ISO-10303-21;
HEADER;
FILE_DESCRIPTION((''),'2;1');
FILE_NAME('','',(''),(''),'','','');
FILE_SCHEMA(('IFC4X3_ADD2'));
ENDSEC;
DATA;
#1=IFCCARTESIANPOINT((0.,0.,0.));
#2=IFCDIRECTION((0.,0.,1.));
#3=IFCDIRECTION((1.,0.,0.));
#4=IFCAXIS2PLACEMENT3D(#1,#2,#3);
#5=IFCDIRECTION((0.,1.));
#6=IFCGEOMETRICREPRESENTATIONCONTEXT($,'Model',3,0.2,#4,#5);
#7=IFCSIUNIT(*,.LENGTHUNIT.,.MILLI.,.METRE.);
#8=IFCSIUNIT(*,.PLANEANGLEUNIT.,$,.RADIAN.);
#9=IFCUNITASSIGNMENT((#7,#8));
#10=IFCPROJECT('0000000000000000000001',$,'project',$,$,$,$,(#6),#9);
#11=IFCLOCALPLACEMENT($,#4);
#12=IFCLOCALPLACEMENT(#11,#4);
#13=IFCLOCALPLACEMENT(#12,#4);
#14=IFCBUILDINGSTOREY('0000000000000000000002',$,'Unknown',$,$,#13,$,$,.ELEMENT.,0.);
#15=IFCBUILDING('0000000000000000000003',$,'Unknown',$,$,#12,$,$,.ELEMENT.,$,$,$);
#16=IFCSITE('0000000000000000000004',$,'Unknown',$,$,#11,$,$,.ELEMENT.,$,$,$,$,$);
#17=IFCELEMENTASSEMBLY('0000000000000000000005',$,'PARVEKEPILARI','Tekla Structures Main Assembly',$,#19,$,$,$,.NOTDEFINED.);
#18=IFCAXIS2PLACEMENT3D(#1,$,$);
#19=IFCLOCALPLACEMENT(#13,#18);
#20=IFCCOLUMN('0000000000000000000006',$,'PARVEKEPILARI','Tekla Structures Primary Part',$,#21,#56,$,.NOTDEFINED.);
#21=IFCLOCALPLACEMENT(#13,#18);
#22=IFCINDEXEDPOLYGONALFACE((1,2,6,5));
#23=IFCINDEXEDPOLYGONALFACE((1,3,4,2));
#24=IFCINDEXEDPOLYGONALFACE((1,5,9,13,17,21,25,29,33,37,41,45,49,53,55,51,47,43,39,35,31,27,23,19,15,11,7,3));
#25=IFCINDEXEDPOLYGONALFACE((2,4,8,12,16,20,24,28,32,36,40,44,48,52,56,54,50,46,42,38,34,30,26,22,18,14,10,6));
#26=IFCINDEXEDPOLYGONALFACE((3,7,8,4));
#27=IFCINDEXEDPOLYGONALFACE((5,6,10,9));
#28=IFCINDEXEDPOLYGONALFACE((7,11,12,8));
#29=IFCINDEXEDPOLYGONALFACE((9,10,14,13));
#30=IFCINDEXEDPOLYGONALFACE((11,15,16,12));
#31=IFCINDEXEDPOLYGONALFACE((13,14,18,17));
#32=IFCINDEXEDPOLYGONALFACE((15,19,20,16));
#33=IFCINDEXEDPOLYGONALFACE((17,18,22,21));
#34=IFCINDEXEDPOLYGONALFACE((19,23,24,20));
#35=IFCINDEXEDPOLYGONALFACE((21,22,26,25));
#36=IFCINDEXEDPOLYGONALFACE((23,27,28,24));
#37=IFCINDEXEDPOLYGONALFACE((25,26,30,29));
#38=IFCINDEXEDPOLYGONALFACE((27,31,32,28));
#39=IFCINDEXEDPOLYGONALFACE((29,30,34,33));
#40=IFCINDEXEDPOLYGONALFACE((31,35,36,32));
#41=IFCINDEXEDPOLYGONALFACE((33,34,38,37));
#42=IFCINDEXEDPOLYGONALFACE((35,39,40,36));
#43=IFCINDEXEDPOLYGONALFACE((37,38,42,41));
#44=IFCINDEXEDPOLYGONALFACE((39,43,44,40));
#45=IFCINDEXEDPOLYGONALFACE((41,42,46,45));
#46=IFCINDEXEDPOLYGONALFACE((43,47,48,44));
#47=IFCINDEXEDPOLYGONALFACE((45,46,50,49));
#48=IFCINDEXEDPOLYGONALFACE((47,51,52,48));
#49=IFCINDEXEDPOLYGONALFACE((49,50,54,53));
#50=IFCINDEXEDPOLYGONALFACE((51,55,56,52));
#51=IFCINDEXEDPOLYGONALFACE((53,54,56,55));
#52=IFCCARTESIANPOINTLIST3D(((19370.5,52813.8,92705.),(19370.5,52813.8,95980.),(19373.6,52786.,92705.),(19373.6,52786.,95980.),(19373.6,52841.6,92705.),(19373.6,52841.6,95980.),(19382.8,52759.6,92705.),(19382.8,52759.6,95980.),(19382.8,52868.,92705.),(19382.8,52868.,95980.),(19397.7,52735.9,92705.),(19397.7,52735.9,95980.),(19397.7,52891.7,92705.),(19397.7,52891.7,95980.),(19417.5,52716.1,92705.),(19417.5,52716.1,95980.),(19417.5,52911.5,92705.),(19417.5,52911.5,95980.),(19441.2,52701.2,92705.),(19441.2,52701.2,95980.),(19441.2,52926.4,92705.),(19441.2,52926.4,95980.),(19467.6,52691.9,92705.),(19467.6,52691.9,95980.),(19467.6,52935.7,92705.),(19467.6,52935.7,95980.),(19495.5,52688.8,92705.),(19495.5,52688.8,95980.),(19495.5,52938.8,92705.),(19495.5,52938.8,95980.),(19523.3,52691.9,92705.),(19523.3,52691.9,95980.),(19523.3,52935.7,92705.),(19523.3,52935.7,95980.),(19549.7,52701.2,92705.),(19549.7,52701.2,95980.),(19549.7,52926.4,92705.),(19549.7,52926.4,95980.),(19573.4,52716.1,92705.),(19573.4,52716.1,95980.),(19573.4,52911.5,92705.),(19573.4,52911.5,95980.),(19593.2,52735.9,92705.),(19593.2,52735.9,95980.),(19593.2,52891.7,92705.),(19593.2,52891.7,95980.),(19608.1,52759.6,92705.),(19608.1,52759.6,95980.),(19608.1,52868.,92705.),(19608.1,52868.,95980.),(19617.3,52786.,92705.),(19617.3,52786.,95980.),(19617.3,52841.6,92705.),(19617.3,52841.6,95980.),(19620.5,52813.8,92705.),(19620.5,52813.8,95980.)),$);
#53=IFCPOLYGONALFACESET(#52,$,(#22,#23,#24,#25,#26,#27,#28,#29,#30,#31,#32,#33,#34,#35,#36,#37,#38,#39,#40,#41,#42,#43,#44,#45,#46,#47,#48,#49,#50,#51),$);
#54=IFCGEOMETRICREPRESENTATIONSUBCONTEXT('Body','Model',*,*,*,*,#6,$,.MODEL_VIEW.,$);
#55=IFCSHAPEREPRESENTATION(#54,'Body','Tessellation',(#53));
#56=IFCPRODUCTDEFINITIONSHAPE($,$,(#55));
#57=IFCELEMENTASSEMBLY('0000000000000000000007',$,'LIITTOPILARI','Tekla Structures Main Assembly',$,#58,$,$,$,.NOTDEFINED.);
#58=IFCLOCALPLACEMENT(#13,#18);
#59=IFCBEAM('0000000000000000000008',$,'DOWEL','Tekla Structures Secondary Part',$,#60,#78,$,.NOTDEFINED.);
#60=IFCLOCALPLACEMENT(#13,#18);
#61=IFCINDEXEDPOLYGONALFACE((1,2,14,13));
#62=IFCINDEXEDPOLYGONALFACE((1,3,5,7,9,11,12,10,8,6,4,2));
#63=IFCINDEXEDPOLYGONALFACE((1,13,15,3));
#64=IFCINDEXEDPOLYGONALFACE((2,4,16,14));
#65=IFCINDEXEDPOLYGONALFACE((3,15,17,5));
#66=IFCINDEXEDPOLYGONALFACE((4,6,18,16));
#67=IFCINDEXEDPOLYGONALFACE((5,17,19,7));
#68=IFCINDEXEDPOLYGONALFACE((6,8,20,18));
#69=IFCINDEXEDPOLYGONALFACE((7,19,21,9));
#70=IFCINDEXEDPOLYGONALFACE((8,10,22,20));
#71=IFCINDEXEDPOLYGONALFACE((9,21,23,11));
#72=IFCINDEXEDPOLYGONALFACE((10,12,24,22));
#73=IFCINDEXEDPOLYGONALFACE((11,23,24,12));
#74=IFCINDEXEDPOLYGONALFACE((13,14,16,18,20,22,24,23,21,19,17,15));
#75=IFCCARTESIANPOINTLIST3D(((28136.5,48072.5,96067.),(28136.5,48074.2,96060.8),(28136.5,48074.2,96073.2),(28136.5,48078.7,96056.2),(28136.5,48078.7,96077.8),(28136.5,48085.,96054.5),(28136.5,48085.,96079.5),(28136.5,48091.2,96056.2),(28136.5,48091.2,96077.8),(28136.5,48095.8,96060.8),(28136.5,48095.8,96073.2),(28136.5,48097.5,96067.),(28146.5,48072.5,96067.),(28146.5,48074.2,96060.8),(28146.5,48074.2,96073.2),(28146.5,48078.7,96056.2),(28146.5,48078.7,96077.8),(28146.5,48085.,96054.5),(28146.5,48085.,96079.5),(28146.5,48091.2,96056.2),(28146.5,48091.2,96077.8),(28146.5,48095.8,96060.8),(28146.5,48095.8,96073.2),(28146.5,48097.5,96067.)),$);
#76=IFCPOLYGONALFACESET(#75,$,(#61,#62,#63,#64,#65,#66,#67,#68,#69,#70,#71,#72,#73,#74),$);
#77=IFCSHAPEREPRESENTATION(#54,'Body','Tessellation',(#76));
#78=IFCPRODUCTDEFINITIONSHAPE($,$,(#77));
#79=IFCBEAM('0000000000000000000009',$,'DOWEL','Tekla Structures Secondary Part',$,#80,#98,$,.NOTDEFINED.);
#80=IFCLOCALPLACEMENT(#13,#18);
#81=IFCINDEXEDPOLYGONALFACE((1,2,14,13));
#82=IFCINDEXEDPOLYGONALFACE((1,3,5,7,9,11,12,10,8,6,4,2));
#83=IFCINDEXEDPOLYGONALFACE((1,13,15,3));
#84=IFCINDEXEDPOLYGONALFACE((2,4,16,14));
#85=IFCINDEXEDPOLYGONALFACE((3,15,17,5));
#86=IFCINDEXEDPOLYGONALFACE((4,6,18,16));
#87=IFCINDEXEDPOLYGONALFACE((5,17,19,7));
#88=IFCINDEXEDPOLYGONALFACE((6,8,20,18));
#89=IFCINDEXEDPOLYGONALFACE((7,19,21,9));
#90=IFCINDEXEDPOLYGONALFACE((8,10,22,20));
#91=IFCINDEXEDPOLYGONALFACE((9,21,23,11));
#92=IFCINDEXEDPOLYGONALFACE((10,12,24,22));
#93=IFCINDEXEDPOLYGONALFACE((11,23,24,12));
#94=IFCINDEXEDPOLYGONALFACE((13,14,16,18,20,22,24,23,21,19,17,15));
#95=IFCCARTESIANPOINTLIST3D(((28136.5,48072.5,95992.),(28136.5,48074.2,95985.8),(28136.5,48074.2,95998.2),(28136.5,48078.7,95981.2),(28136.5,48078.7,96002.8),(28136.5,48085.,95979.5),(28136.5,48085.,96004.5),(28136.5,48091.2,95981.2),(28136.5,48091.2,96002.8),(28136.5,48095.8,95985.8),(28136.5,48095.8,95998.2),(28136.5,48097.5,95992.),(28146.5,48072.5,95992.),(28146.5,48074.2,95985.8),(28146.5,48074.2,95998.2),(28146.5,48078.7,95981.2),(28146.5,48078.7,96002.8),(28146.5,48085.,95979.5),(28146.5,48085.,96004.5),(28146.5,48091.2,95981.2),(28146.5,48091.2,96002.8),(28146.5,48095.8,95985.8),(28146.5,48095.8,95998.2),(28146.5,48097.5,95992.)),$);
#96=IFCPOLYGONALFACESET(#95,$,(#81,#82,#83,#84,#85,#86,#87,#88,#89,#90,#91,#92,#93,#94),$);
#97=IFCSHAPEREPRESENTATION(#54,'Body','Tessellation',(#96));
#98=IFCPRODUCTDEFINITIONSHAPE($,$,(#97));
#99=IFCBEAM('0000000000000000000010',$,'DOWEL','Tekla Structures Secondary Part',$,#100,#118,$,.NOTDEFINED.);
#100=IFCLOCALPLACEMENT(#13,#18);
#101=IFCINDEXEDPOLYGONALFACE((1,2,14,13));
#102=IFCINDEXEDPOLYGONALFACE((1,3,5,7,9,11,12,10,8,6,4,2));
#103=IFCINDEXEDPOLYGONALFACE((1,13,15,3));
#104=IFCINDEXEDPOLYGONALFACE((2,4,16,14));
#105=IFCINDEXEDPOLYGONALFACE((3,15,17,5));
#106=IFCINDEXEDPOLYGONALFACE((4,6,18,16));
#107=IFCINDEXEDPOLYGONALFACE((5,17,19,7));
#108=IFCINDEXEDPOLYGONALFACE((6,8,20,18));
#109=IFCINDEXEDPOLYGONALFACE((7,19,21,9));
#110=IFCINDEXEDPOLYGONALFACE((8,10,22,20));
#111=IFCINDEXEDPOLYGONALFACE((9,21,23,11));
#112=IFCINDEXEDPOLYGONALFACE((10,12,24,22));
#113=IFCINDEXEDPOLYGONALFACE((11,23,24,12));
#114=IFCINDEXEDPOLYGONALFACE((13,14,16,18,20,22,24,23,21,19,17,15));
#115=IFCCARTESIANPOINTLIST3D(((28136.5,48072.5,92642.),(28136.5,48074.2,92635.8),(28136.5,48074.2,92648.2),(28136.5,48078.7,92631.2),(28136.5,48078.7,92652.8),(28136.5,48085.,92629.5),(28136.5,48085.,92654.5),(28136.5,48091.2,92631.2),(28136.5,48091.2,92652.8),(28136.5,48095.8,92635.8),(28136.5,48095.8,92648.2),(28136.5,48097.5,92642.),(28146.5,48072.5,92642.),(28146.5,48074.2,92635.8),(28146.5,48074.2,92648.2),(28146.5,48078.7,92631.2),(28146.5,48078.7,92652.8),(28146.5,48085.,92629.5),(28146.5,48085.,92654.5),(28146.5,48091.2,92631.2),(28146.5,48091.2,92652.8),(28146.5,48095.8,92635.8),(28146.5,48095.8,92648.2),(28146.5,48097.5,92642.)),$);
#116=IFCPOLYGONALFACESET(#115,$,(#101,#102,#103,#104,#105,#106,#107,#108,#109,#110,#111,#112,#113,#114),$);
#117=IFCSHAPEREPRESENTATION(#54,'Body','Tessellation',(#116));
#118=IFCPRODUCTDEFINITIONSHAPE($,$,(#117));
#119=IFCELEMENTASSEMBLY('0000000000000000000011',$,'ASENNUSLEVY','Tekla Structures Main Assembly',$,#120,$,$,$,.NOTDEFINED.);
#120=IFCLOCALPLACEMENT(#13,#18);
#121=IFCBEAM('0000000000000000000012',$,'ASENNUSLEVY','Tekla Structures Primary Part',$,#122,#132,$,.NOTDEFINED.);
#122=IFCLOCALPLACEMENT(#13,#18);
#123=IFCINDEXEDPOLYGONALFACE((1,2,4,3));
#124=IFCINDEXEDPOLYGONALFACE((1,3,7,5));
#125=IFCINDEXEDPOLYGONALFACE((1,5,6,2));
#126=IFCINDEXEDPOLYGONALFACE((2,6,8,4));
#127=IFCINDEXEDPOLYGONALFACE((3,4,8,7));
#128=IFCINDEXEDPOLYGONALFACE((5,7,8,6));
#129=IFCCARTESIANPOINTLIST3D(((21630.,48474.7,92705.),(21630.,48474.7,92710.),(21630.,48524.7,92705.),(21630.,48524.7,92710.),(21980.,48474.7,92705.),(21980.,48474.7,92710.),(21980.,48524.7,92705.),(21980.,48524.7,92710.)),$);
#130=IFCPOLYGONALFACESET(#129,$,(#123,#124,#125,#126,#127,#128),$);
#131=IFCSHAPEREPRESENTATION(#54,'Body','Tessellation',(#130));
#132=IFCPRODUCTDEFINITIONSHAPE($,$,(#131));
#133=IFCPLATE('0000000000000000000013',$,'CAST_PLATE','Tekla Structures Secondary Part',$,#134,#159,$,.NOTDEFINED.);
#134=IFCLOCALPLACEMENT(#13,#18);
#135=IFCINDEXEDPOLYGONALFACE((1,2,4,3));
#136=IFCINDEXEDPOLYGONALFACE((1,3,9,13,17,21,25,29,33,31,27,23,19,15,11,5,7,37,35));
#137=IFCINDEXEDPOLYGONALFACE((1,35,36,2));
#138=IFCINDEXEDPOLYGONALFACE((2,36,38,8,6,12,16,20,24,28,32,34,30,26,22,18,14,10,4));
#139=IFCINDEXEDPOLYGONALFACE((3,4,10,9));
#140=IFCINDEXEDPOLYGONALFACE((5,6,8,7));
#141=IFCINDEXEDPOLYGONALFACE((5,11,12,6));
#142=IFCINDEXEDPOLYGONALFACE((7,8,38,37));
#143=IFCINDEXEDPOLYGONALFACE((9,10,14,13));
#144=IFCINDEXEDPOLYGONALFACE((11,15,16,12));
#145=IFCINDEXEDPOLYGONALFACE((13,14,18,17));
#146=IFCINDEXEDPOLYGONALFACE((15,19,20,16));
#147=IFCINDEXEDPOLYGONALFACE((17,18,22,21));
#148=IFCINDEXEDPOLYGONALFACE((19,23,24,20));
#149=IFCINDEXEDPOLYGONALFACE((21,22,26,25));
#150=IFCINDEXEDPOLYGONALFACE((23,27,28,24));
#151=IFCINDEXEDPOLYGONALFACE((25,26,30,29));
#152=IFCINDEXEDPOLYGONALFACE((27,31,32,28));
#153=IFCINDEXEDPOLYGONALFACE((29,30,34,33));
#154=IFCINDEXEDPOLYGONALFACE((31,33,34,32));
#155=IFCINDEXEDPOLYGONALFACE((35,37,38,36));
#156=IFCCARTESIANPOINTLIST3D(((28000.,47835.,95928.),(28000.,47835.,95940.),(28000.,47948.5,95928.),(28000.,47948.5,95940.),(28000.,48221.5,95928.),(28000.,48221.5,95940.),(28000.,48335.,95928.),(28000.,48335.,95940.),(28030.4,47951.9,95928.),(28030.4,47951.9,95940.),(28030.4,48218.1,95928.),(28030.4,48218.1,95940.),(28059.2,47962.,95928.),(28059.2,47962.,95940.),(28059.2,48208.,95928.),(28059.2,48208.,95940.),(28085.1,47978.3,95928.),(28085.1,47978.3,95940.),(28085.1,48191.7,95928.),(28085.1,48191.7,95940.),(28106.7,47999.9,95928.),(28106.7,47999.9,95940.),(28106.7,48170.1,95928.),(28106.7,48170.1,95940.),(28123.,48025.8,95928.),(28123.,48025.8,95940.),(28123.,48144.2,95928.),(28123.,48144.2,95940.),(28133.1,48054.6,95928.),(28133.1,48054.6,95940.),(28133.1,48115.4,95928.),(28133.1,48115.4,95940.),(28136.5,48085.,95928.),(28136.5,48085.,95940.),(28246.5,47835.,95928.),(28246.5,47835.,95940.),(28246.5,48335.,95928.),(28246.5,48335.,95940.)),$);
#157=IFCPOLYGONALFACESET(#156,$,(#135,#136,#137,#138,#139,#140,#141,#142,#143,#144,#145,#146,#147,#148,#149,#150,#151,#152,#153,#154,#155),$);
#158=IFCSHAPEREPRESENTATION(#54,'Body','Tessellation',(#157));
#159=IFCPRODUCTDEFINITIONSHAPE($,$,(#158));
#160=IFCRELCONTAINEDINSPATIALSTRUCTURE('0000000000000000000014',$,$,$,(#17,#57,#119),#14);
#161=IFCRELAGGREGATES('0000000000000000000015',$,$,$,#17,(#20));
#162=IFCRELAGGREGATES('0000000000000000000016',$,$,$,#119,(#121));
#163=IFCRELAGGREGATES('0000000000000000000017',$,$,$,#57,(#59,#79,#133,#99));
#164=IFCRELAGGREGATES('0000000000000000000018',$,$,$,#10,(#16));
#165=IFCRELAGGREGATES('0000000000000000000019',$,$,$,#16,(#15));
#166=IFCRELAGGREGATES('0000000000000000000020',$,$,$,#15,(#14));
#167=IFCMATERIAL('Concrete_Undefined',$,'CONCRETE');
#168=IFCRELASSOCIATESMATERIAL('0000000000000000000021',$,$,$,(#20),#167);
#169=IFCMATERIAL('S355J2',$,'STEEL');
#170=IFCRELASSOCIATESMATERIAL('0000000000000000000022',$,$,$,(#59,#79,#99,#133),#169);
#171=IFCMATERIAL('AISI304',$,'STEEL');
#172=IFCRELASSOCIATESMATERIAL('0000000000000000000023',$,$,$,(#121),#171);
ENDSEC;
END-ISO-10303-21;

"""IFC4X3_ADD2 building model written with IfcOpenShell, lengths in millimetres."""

from ifc_helpers import new_model, si_unit, direction, frame, origin_with_axes, place, context, subcontext, project, spatial, line, indexed_curve, outline, extrude, material, element, aggregate, save


model = new_model("IFC4X3_ADD2")

# Units and contexts
model_context = context("Model", 3, precision=0.2, world=origin_with_axes(), true_north=direction((0.0, 1.0)))
body_context = subcontext(model_context, "Body", "Model", "MODEL_VIEW")
ifc_project = project(units=[si_unit("LENGTHUNIT", "METRE", prefix="MILLI"), si_unit("PLANEANGLEUNIT", "RADIAN")], contexts=[model_context])

# Site, building, storey
site_placement = place(None, origin_with_axes())
site = spatial("IfcSite", under=ifc_project, at=site_placement, Name="Unknown", CompositionType="ELEMENT")
building_placement = place(site_placement, origin_with_axes())
building = spatial("IfcBuilding", under=site, at=building_placement, Name="Unknown", CompositionType="ELEMENT")
storey_placement = place(building_placement, origin_with_axes())
storey = spatial("IfcBuildingStorey", under=building, at=storey_placement, Name="Unknown", CompositionType="ELEMENT", Elevation=0.0)

# Element assembly, column
assembly_1_placement = place(storey_placement, frame((19495.5, 52813.8, 92705.0), z_axis=(-1.0, 0.0, 0.0), x_axis=(0.0, 0.0, 1.0)))
assembly_1 = element("IfcElementAssembly", 1, at=assembly_1_placement, inside=storey, Name="PARVEKEPILARI", Description="Tekla Structures Main Assembly", PredefinedType="NOTDEFINED")
ifc_material_1 = material(Name="Concrete_Undefined", Category="CONCRETE")
column_placement = place(assembly_1_placement, origin_with_axes())
column = element("IfcColumn", 2, at=column_placement, material=ifc_material_1, Name="PARVEKEPILARI", Description="Tekla Structures Primary Part", PredefinedType="NOTDEFINED", context=body_context, shape_type="SolidModel", body=[
    extrude(outline(indexed_curve([(125.0, 0.0), (121.9, 27.8), (112.6, 54.2), (97.7, 77.9), (77.9, 97.7), (54.2, 112.6), (27.8, 121.9), (0.0, 125.0), (-27.8, 121.9), (-54.2, 112.6), (-77.9, 97.7), (-97.7, 77.9), (-112.6, 54.2), (-121.9, 27.8), (-125.0, 0.0), (-121.9, -27.8), (-112.6, -54.2), (-97.7, -77.9), (-77.9, -97.7), (-54.2, -112.6), (-27.8, -121.9), (0.0, -125.0), (27.8, -121.9), (54.2, -112.6), (77.9, -97.7), (97.7, -77.9), (112.6, -54.2), (121.9, -27.8)], segments=[line(1, 2, 3, 4, 5, 6, 7, 8, 9, 10, 11, 12, 13, 14, 15, 16, 17, 18, 19, 20, 21, 22, 23, 24, 25, 26, 27, 28, 1)])), frame((0.0, 0.0, 0.0), z_axis=(-1.0, 0.0, 0.0), x_axis=(0.0, 0.0, 1.0)), (0.0, 0.0, -1.0), 3275.0),
])
aggregate(assembly_1, [column])

# Element assembly, beams
assembly_2_placement = place(storey_placement, frame((28000.0, 48085.0, 87950.0), z_axis=(-1.0, 0.0, 0.0), x_axis=(0.0, 0.0, 1.0)))
assembly_2 = element("IfcElementAssembly", 3, at=assembly_2_placement, inside=storey, Name="LIITTOPILARI", Description="Tekla Structures Main Assembly", PredefinedType="NOTDEFINED")
ifc_material_2 = material(Name="S355J2", Category="STEEL")
beam_1_placement = place(assembly_2_placement, frame((8117.0, 0.0, -146.5), z_axis=(0.0, 1.0, 0.0), x_axis=(0.0, 0.0, 1.0)))
beam_1 = element("IfcBeam", 4, at=beam_1_placement, material=ifc_material_2, Name="DOWEL", Description="Tekla Structures Secondary Part", PredefinedType="NOTDEFINED", context=body_context, shape_type="SolidModel", body=[
    extrude(outline(indexed_curve([(12.5, 0.0), (10.8, 6.2), (6.2, 10.8), (0.0, 12.5), (-6.2, 10.8), (-10.8, 6.2), (-12.5, 0.0), (-10.8, -6.2), (-6.2, -10.8), (0.0, -12.5), (6.2, -10.8), (10.8, -6.2)], segments=[line(1, 2, 3, 4, 5, 6, 7, 8, 9, 10, 11, 12, 1)])), frame((0.0, 0.0, 0.0), z_axis=(-1.0, 0.0, 0.0), x_axis=(0.0, 0.0, 1.0)), (0.0, 0.0, -1.0), 10.0),
])
beam_2_placement = place(assembly_2_placement, frame((8042.0, 0.0, -146.5), z_axis=(0.0, 1.0, 0.0), x_axis=(0.0, 0.0, 1.0)))
beam_2 = element("IfcBeam", 5, at=beam_2_placement, material=ifc_material_2, Name="DOWEL", Description="Tekla Structures Secondary Part", PredefinedType="NOTDEFINED", context=body_context, shape_type="SolidModel", body=[
    extrude(outline(indexed_curve([(12.5, 0.0), (10.8, 6.2), (6.2, 10.8), (0.0, 12.5), (-6.2, 10.8), (-10.8, 6.2), (-12.5, 0.0), (-10.8, -6.2), (-6.2, -10.8), (0.0, -12.5), (6.2, -10.8), (10.8, -6.2)], segments=[line(1, 2, 3, 4, 5, 6, 7, 8, 9, 10, 11, 12, 1)])), frame((0.0, 0.0, 0.0), z_axis=(-1.0, 0.0, 0.0), x_axis=(0.0, 0.0, 1.0)), (0.0, 0.0, -1.0), 10.0),
])
beam_3_placement = place(assembly_2_placement, frame((4692.0, 0.0, -146.5), z_axis=(0.0, 1.0, 0.0), x_axis=(0.0, 0.0, 1.0)))
beam_3 = element("IfcBeam", 6, at=beam_3_placement, material=ifc_material_2, Name="DOWEL", Description="Tekla Structures Secondary Part", PredefinedType="NOTDEFINED", context=body_context, shape_type="SolidModel", body=[
    extrude(outline(indexed_curve([(12.5, 0.0), (10.8, 6.2), (6.2, 10.8), (0.0, 12.5), (-6.2, 10.8), (-10.8, 6.2), (-12.5, 0.0), (-10.8, -6.2), (-6.2, -10.8), (0.0, -12.5), (6.2, -10.8), (10.8, -6.2)], segments=[line(1, 2, 3, 4, 5, 6, 7, 8, 9, 10, 11, 12, 1)])), frame((0.0, 0.0, 0.0), z_axis=(-1.0, 0.0, 0.0), x_axis=(0.0, 0.0, 1.0)), (0.0, 0.0, -1.0), 10.0),
])

# Element assembly, beam
assembly_3_placement = place(storey_placement, frame((21980.0, 48499.7, 92707.5), z_axis=(0.0, 0.0, 1.0), x_axis=(-1.0, 0.0, 0.0)))
assembly_3 = element("IfcElementAssembly", 7, at=assembly_3_placement, inside=storey, Name="ASENNUSLEVY", Description="Tekla Structures Main Assembly", PredefinedType="NOTDEFINED")
ifc_material_3 = material(Name="AISI304", Category="STEEL")
beam_4_placement = place(assembly_3_placement, origin_with_axes())
beam_4 = element("IfcBeam", 8, at=beam_4_placement, material=ifc_material_3, Name="ASENNUSLEVY", Description="Tekla Structures Primary Part", PredefinedType="NOTDEFINED", context=body_context, shape_type="SolidModel", body=[
    extrude(outline(indexed_curve([(-2.5, -25.0), (2.5, -25.0), (2.5, 25.0), (-2.5, 25.0)], segments=[line(1, 2, 3, 4, 1)])), frame((0.0, 0.0, 0.0), z_axis=(-1.0, 0.0, 0.0), x_axis=(0.0, 0.0, 1.0)), (0.0, 0.0, -1.0), 350.0),
])
aggregate(assembly_3, [beam_4])

# Plate, voiding feature
plate_1_placement = place(assembly_2_placement, frame((7984.0, 250.0, -246.5), z_axis=(1.0, 0.0, 0.0), x_axis=(0.0, 0.0, 1.0)))
plate_1 = element("IfcPlate", 9, at=plate_1_placement, material=ifc_material_2, Name="CAST_PLATE", Description="Tekla Structures Secondary Part", PredefinedType="NOTDEFINED", context=body_context, shape_type="SolidModel", body=[
    extrude(outline(indexed_curve([(0.0, 0.0), (246.5, 0.0), (246.5, 500.0), (0.0, 500.0)], segments=[line(1, 2, 3, 4, 1)])), frame((0.0, 0.0, 6.0), z_axis=(0.0, 0.0, 1.0), x_axis=(1.0, 0.0, 0.0)), (0.0, 0.0, -1.0), 12.0),
])
voiding_feature_1_placement = place(plate_1_placement, frame((246.5, 250.0, 16.0), z_axis=(0.0, 1.0, 0.0), x_axis=(0.0, 0.0, -1.0)))
element("IfcVoidingFeature", 10, at=voiding_feature_1_placement, cuts=plate_1, Name="BEAM", PredefinedType="HOLE", context=body_context, shape_type="SolidModel", body=[
    extrude(outline(indexed_curve([(136.5, 0.0), (133.1, 30.4), (123.0, 59.2), (106.7, 85.1), (85.1, 106.7), (59.2, 123.0), (30.4, 133.1), (0.0, 136.5), (-30.4, 133.1), (-59.2, 123.0), (-85.1, 106.7), (-106.7, 85.1), (-123.0, 59.2), (-133.1, 30.4), (-136.5, 0.0), (-133.1, -30.4), (-123.0, -59.2), (-106.7, -85.1), (-85.1, -106.7), (-59.2, -123.0), (-30.4, -133.1), (0.0, -136.5), (30.4, -133.1), (59.2, -123.0), (85.1, -106.7), (106.7, -85.1), (123.0, -59.2), (133.1, -30.4)], segments=[line(1, 2, 3, 4, 5, 6, 7, 8, 9, 10, 11, 12, 13, 14, 15, 16, 17, 18, 19, 20, 21, 22, 23, 24, 25, 26, 27, 28, 1)])), frame((0.0, 0.0, 0.0), z_axis=(-1.0, 0.0, 0.0), x_axis=(0.0, 0.0, 1.0)), (0.0, 0.0, -1.0), 32.0),
])

aggregate(assembly_2, [beam_1, beam_2, plate_1, beam_3])

save(model, "model.ifc")
